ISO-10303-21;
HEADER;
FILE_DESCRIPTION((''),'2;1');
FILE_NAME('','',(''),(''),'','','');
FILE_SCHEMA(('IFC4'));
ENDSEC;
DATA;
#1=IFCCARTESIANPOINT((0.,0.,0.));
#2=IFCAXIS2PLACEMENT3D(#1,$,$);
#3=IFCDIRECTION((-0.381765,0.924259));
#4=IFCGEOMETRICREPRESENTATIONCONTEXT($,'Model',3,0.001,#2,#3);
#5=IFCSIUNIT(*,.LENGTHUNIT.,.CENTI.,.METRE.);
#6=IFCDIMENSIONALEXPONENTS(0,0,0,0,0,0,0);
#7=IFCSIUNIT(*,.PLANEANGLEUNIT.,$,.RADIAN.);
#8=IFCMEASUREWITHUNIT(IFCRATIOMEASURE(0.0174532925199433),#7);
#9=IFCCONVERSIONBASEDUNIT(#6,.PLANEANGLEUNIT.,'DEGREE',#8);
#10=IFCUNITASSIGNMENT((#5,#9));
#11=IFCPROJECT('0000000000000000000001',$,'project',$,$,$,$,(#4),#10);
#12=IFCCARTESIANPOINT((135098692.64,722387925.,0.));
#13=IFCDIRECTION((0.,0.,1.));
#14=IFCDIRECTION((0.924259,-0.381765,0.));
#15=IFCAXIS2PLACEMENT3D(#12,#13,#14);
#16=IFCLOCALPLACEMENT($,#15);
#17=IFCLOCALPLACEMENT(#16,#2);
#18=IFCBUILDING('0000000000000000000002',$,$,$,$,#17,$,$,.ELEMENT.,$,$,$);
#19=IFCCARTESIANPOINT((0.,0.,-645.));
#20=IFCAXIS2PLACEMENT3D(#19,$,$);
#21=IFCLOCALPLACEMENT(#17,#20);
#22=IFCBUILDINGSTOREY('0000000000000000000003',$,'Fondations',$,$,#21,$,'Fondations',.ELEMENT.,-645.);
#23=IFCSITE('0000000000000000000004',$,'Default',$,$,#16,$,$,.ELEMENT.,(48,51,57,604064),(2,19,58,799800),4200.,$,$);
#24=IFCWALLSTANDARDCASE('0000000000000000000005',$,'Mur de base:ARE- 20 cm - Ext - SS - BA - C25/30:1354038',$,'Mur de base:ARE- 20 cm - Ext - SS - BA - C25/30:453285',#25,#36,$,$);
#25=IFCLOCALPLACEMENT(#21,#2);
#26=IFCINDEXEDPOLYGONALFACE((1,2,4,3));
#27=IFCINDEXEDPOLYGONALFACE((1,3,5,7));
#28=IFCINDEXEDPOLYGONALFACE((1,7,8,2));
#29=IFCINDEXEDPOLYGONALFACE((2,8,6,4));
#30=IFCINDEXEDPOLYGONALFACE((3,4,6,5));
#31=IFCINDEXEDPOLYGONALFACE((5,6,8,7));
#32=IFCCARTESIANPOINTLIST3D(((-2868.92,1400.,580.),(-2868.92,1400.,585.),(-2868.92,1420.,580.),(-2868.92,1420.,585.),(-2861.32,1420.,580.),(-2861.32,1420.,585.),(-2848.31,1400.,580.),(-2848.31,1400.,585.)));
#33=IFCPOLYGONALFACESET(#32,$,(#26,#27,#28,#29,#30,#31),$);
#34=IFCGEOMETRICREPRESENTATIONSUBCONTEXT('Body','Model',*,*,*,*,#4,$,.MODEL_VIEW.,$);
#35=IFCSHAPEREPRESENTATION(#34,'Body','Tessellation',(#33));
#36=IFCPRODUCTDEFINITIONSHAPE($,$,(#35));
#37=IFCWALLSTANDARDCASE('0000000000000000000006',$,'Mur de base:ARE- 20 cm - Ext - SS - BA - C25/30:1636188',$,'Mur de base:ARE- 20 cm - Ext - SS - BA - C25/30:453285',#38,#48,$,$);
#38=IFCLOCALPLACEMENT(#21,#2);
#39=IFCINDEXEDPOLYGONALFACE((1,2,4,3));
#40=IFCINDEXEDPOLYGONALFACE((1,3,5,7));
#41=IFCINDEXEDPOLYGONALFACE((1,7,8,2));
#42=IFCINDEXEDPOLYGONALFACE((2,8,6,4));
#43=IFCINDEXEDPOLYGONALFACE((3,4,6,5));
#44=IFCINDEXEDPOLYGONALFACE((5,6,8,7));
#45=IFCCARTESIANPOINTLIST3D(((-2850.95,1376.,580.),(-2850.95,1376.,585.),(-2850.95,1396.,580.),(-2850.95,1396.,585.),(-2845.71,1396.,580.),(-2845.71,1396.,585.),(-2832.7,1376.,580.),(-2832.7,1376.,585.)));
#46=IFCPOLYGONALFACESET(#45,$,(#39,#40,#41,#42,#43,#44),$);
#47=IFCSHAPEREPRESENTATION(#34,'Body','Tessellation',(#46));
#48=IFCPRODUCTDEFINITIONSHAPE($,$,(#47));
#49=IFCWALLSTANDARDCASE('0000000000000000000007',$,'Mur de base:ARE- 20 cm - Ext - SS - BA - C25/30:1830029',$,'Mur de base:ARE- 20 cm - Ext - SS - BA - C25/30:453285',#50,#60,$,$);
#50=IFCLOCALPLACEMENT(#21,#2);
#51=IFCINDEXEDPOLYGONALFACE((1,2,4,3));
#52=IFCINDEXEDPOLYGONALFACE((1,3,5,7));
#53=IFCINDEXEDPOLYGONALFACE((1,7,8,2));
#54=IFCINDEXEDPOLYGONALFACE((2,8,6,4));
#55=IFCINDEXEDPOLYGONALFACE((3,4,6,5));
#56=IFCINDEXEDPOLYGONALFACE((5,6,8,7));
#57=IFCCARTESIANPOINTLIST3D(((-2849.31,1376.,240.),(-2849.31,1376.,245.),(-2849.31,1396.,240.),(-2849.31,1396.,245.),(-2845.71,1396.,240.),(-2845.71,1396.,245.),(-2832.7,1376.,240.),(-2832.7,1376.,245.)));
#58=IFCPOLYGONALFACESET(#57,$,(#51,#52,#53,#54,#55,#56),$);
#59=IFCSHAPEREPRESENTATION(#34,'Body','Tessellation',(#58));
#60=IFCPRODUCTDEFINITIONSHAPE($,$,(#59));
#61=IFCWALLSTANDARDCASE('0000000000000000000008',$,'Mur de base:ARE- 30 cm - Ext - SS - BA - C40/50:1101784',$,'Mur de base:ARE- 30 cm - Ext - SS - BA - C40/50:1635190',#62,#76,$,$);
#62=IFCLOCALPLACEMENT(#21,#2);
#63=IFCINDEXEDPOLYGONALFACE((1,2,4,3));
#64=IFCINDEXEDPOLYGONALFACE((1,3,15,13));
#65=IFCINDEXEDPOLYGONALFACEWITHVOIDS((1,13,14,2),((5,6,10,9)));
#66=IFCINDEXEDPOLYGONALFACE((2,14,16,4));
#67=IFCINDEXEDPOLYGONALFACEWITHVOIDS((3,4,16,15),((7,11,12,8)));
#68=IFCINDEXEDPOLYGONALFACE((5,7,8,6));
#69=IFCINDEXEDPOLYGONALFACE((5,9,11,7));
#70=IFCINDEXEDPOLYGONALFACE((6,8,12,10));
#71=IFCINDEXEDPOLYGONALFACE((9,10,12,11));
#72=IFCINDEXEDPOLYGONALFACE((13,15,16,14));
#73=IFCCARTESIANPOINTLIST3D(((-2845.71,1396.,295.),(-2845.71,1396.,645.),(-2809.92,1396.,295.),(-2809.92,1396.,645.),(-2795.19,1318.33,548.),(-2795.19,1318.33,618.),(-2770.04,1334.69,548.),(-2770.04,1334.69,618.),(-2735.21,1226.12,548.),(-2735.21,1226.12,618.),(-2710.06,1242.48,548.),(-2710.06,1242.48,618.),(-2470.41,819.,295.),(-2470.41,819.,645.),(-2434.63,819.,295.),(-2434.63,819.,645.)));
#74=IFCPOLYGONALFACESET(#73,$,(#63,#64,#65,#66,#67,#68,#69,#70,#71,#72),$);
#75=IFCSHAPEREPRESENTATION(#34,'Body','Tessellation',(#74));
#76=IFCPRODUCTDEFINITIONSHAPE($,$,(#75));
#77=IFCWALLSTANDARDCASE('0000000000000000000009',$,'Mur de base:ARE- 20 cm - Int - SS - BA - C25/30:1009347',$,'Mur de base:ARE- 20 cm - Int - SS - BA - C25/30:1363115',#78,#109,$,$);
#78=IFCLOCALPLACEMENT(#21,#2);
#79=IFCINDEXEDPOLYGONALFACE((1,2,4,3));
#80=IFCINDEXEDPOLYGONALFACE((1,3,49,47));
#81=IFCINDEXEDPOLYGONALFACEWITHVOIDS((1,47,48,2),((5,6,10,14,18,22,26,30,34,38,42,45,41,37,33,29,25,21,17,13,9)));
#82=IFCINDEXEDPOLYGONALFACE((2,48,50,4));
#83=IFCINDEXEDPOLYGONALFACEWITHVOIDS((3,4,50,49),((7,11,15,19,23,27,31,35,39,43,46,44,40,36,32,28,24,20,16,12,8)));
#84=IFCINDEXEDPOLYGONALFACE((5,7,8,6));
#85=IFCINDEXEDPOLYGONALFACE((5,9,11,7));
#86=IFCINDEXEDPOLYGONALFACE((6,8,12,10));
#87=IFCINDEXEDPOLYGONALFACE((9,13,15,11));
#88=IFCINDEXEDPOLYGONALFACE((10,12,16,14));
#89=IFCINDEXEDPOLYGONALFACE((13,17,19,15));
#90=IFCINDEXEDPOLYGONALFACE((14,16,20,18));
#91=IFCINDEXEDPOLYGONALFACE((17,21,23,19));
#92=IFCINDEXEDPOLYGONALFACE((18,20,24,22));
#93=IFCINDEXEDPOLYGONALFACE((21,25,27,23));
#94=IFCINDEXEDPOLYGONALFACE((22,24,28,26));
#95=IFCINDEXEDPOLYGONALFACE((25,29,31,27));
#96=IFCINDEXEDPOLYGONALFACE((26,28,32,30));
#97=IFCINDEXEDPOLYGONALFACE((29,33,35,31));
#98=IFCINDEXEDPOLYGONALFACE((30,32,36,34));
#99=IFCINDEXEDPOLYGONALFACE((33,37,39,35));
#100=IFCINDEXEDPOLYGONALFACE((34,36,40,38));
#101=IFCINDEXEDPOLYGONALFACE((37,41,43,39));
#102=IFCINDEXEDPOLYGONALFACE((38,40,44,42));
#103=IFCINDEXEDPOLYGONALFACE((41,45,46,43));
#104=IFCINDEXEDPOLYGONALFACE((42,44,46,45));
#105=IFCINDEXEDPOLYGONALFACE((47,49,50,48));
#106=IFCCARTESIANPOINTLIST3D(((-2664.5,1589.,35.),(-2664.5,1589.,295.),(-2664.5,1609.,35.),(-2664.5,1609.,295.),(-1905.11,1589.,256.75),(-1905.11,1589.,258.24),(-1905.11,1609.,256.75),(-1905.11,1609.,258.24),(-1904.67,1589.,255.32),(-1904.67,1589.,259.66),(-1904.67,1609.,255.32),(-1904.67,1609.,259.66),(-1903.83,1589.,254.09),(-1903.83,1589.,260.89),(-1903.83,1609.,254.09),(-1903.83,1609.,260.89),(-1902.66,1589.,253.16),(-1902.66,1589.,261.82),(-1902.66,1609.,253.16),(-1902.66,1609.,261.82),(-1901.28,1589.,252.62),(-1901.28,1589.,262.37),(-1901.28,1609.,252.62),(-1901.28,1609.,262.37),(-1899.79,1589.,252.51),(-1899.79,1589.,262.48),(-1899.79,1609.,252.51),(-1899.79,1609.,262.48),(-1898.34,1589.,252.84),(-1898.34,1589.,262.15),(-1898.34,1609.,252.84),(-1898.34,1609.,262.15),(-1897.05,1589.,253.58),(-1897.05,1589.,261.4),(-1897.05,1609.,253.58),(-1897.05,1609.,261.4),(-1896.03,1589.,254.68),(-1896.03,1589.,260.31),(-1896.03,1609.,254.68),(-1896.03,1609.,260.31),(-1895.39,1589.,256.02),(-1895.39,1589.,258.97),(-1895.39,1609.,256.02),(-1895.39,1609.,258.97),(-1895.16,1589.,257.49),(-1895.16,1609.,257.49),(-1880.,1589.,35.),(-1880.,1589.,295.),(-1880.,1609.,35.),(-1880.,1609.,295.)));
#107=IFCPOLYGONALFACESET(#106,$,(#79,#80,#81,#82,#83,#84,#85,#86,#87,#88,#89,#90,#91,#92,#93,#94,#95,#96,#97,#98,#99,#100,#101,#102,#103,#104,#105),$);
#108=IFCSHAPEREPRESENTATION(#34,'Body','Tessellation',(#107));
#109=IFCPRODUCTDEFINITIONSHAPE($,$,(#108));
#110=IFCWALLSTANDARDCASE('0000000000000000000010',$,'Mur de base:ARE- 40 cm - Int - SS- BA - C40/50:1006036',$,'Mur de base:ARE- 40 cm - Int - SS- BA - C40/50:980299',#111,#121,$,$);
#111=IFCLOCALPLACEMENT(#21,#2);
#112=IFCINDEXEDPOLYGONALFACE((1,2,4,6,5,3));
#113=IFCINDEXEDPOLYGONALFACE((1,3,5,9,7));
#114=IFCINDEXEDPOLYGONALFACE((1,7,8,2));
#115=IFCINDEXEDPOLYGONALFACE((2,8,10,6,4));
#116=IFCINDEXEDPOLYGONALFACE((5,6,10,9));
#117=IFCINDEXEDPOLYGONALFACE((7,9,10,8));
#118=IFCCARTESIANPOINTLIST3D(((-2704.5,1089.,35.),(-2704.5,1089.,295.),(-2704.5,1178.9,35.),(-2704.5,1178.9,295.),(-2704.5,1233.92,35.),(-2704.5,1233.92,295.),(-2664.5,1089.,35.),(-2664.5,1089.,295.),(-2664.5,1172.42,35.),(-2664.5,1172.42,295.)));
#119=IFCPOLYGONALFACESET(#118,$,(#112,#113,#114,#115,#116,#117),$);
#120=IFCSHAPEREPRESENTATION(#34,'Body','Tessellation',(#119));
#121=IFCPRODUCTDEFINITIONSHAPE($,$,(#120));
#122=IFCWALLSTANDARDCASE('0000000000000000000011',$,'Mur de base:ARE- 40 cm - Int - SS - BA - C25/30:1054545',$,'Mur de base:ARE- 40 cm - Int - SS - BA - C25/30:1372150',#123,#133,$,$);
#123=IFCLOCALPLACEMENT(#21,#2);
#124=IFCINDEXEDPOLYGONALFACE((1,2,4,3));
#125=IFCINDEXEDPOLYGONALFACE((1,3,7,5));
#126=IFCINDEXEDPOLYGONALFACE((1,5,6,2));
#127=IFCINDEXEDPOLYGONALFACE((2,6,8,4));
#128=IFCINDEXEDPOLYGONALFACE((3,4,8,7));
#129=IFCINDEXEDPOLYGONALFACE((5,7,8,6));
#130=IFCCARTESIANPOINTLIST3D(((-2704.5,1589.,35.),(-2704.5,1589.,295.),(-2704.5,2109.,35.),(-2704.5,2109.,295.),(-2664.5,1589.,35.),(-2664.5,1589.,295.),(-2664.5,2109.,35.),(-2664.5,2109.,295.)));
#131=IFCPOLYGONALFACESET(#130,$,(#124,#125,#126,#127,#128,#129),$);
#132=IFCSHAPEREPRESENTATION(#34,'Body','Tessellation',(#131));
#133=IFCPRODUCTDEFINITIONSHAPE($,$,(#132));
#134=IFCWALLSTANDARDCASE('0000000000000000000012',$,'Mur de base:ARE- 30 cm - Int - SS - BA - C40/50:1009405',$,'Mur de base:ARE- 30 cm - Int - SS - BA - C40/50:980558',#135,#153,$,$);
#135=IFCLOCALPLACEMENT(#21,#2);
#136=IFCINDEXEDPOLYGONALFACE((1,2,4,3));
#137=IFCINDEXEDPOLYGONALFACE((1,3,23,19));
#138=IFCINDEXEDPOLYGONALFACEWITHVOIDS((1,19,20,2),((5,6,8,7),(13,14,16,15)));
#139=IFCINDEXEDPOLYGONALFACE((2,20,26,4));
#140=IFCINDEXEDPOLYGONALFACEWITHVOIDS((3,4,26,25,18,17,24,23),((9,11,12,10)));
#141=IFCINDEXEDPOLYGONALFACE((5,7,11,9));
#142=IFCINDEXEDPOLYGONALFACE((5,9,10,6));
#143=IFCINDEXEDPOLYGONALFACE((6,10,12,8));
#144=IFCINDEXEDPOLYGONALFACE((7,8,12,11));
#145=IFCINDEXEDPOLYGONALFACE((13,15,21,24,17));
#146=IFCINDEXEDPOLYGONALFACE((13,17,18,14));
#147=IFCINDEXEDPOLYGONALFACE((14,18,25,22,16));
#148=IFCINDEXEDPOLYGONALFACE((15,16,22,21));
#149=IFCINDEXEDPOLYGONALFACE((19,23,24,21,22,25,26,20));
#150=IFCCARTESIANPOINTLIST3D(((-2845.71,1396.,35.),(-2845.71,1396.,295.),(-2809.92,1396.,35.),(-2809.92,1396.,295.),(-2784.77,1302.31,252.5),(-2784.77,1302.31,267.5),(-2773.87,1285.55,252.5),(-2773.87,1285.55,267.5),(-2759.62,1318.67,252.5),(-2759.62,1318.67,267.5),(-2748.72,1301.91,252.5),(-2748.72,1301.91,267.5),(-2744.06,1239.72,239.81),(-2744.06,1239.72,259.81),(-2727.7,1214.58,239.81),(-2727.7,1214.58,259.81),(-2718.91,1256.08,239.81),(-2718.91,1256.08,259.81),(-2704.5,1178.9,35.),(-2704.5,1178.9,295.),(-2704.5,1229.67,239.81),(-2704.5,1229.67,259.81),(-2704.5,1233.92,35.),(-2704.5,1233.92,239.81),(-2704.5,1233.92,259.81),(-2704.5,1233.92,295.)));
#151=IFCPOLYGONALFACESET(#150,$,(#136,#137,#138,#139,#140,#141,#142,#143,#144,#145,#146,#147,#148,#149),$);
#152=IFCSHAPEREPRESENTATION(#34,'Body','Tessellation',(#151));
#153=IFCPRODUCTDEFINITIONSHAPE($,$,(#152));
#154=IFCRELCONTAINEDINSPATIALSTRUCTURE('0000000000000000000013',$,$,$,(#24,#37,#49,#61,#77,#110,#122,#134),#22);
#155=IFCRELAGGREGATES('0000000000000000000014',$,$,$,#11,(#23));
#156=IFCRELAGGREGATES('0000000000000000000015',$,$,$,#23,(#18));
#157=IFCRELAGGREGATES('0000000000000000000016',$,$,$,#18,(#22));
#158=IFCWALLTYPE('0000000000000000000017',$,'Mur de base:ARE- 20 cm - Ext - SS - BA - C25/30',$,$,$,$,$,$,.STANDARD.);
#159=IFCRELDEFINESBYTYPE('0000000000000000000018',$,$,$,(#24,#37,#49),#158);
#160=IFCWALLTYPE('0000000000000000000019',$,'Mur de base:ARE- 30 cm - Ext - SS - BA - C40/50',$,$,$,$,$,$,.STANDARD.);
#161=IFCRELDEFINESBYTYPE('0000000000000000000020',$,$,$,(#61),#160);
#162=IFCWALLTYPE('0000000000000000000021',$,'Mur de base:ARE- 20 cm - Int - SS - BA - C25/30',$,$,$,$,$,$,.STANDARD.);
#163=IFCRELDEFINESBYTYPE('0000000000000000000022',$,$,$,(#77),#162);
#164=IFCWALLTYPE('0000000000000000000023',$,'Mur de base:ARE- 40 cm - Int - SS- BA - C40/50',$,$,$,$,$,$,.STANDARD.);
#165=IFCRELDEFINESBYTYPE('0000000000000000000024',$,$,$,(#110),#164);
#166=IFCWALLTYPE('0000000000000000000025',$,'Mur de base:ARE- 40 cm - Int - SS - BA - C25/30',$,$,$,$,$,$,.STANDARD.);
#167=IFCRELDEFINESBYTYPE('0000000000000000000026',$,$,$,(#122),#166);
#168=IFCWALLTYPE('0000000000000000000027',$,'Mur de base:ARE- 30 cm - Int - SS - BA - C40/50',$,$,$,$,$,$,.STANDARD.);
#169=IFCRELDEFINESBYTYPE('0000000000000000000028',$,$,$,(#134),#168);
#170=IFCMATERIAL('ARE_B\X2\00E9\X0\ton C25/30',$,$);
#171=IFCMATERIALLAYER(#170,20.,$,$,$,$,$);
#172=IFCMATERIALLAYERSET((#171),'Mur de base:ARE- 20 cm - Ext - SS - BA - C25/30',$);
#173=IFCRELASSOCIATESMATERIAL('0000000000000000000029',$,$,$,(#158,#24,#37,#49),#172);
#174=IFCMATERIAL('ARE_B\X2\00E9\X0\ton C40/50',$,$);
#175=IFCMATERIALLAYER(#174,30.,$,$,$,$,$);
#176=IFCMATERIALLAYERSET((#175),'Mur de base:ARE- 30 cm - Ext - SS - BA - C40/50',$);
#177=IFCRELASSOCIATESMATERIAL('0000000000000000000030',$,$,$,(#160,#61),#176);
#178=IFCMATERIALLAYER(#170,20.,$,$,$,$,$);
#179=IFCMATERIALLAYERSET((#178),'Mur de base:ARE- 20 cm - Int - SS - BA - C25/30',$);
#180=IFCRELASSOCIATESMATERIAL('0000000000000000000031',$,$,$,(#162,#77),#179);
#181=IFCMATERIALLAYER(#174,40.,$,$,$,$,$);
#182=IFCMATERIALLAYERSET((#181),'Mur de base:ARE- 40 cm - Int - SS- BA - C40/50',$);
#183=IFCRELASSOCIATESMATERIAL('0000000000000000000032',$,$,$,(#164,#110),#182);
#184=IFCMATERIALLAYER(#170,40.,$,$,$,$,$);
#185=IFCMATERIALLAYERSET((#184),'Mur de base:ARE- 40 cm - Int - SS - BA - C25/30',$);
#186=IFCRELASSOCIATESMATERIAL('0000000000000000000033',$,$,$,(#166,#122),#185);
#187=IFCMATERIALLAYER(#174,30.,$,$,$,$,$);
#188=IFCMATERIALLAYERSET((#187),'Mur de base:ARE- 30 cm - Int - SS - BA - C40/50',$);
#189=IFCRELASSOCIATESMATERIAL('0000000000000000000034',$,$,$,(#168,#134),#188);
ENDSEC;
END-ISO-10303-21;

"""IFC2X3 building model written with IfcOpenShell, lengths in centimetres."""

from ifc_helpers import new_model, entity, si_unit, converted_unit, direction, frame, frame_2d, origin, origin_2d_with_axis, place, context, subcontext, project, spatial, polyline, rectangle, circle, outline, extrude, material, layer, layer_set, layer_usage, type_object, element, save


model = new_model("IFC2X3")

# Units and contexts
model_context = context("Model", 3, precision=0.001, world=origin(), true_north=direction((-0.381765, 0.924259)))
body_context = subcontext(model_context, "Body", "Model", "MODEL_VIEW")
ifc_project = project(units=[si_unit("LENGTHUNIT", "METRE", prefix="CENTI"), converted_unit("PLANEANGLEUNIT", "DEGREE", entity("IfcRatioMeasure", 0.0174532925199433), si_unit("PLANEANGLEUNIT", "RADIAN"), dimensions=[0, 0, 0, 0, 0, 0, 0])], contexts=[model_context])

# Site, building, storey
site_placement = place(None, frame((135098692.64, 722387925.0, 0.0), z_axis=(0.0, 0.0, 1.0), x_axis=(0.924259, -0.381765, 0.0)))
site = spatial("IfcSite", under=ifc_project, at=site_placement, Name="Default", CompositionType="ELEMENT", RefLatitude=(48, 51, 57, 604064), RefLongitude=(2, 19, 58, 799800), RefElevation=4200.0)
building_placement = place(site_placement, origin())
building = spatial("IfcBuilding", under=site, at=building_placement, CompositionType="ELEMENT")
storey_placement = place(building_placement, frame((0.0, 0.0, -645.0)))
storey = spatial("IfcBuildingStorey", under=building, at=storey_placement, Name="Fondations", LongName="Fondations", CompositionType="ELEMENT", Elevation=-645.0)

# Shared definitions
ifc_material_1 = material(Name="ARE_Béton C25/30")

# Walls
ifc_layer_1 = layer(ifc_material_1, 20.0)
ifc_layer_set_1 = layer_set([ifc_layer_1], Name="Mur de base:ARE- 20 cm - Ext - SS - BA - C25/30")
ifc_layer_usage_1 = layer_usage(ifc_layer_set_1, "AXIS2", "NEGATIVE", 10.0)
wall_type_1 = type_object("IfcWallType", Name="Mur de base:ARE- 20 cm - Ext - SS - BA - C25/30", PredefinedType="STANDARD", material=ifc_layer_set_1)
wall_1_placement = place(storey_placement, frame((-2868.92, 1410.0, 580.0)))
element("IfcWallStandardCase", 1, at=wall_1_placement, inside=storey, type_object=wall_type_1, material=ifc_layer_usage_1, Name="Mur de base:ARE- 20 cm - Ext - SS - BA - C25/30:1354038", ObjectType="Mur de base:ARE- 20 cm - Ext - SS - BA - C25/30:453285", context=body_context, shape_type="SweptSolid", body=[
    extrude(outline(polyline([(20.61, -10.0), (7.6, 10.0), (0.0, 10.0), (0.0, -10.0), (20.61, -10.0)])), origin(), (0.0, 0.0, 1.0), 5.0),
])
ifc_layer_usage_2 = layer_usage(ifc_layer_set_1, "AXIS2", "NEGATIVE", 10.0)
wall_2_placement = place(storey_placement, frame((-2850.95, 1386.0, 580.0)))
element("IfcWallStandardCase", 2, at=wall_2_placement, inside=storey, type_object=wall_type_1, material=ifc_layer_usage_2, Name="Mur de base:ARE- 20 cm - Ext - SS - BA - C25/30:1636188", ObjectType="Mur de base:ARE- 20 cm - Ext - SS - BA - C25/30:453285", context=body_context, shape_type="SweptSolid", body=[
    extrude(outline(polyline([(18.26, -10.0), (5.25, 10.0), (0.0, 10.0), (0.0, -10.0), (18.26, -10.0)])), origin(), (0.0, 0.0, 1.0), 5.0),
])
ifc_layer_usage_3 = layer_usage(ifc_layer_set_1, "AXIS2", "NEGATIVE", 10.0)
wall_3_placement = place(storey_placement, frame((-2849.31, 1386.0, 240.0)))
element("IfcWallStandardCase", 3, at=wall_3_placement, inside=storey, type_object=wall_type_1, material=ifc_layer_usage_3, Name="Mur de base:ARE- 20 cm - Ext - SS - BA - C25/30:1830029", ObjectType="Mur de base:ARE- 20 cm - Ext - SS - BA - C25/30:453285", context=body_context, shape_type="SweptSolid", body=[
    extrude(outline(polyline([(16.61, -10.0), (3.6, 10.0), (0.0, 10.0), (0.0, -10.0), (16.61, -10.0)])), origin(), (0.0, 0.0, 1.0), 5.0),
])

# Walls, openings
ifc_material_2 = material(Name="ARE_Béton C40/50")
ifc_layer_2 = layer(ifc_material_2, 30.0)
ifc_layer_set_2 = layer_set([ifc_layer_2], Name="Mur de base:ARE- 30 cm - Ext - SS - BA - C40/50")
ifc_layer_usage_4 = layer_usage(ifc_layer_set_2, "AXIS2", "NEGATIVE", 15.0)
wall_type_2 = type_object("IfcWallType", Name="Mur de base:ARE- 30 cm - Ext - SS - BA - C40/50", PredefinedType="STANDARD", material=ifc_layer_set_2)
wall_4_placement = place(storey_placement, frame((-2833.13, 1404.18, 295.0), z_axis=(0.0, 0.0, 1.0), x_axis=(0.545236, -0.838282, 0.0)))
wall_4 = element("IfcWallStandardCase", 4, at=wall_4_placement, inside=storey, type_object=wall_type_2, material=ifc_layer_usage_4, Name="Mur de base:ARE- 30 cm - Ext - SS - BA - C40/50:1101784", ObjectType="Mur de base:ARE- 30 cm - Ext - SS - BA - C40/50:1635190", context=body_context, shape_type="SweptSolid", body=[
    extrude(outline(polyline([(688.31, -15.0), (707.82, 15.0), (672.04, 15.0), (19.51, 15.0), (0.0, -15.0), (688.31, -15.0)])), origin(), (0.0, 0.0, 1.0), 350.0),
])
opening_1_placement = place(wall_4_placement, origin())
element("IfcOpeningElement", 5, at=opening_1_placement, cuts=wall_4, ObjectType="Opening", context=body_context, shape_type="SweptSolid", body=[
    extrude(rectangle(XDim=70.0, YDim=110.0, at=frame_2d((0.0, 0.0), x_axis=(1.0, 0.0))), frame((147.65, -15.0, 288.0), z_axis=(0.0, 1.0, 0.0), x_axis=(0.0, 0.0, -1.0)), (0.0, 0.0, 1.0), 30.0),
])
ifc_layer_3 = layer(ifc_material_1, 20.0)
ifc_layer_set_3 = layer_set([ifc_layer_3], Name="Mur de base:ARE- 20 cm - Int - SS - BA - C25/30")
ifc_layer_usage_5 = layer_usage(ifc_layer_set_3, "AXIS2", "NEGATIVE", 10.0)
wall_type_3 = type_object("IfcWallType", Name="Mur de base:ARE- 20 cm - Int - SS - BA - C25/30", PredefinedType="STANDARD", material=ifc_layer_set_3)
wall_5_placement = place(storey_placement, frame((-2664.5, 1599.0, 35.0)))
wall_5 = element("IfcWallStandardCase", 6, at=wall_5_placement, inside=storey, type_object=wall_type_3, material=ifc_layer_usage_5, Name="Mur de base:ARE- 20 cm - Int - SS - BA - C25/30:1009347", ObjectType="Mur de base:ARE- 20 cm - Int - SS - BA - C25/30:1363115", context=body_context, shape_type="SweptSolid", body=[
    extrude(rectangle(XDim=784.5, YDim=20.0, at=frame_2d((392.25, 0.0), x_axis=(-1.0, 0.0))), origin(), (0.0, 0.0, 1.0), 260.0),
])
opening_2_placement = place(wall_5_placement, origin())
element("IfcOpeningElement", 7, at=opening_2_placement, cuts=wall_5, ObjectType="Opening", context=body_context, shape_type="SweptSolid", body=[
    extrude(circle(Radius=5.0, at=origin_2d_with_axis()), frame((764.34, -10.0, 222.49), z_axis=(0.0, 1.0, 0.0), x_axis=(1.0, 0.0, 0.0)), (0.0, 0.0, 1.0), 20.0),
])

# Walls
ifc_layer_4 = layer(ifc_material_2, 40.0)
ifc_layer_set_4 = layer_set([ifc_layer_4], Name="Mur de base:ARE- 40 cm - Int - SS- BA - C40/50")
ifc_layer_usage_6 = layer_usage(ifc_layer_set_4, "AXIS2", "NEGATIVE", 20.0)
wall_type_4 = type_object("IfcWallType", Name="Mur de base:ARE- 40 cm - Int - SS- BA - C40/50", PredefinedType="STANDARD", material=ifc_layer_set_4)
wall_6_placement = place(storey_placement, frame((-2684.5, 1089.0, 35.0), z_axis=(0.0, 0.0, 1.0), x_axis=(0.0, 1.0, 0.0)))
element("IfcWallStandardCase", 8, at=wall_6_placement, inside=storey, type_object=wall_type_4, material=ifc_layer_usage_6, Name="Mur de base:ARE- 40 cm - Int - SS- BA - C40/50:1006036", ObjectType="Mur de base:ARE- 40 cm - Int - SS- BA - C40/50:980299", context=body_context, shape_type="SweptSolid", body=[
    extrude(outline(polyline([(83.42, -20.0), (144.92, 20.0), (89.9, 20.0), (0.0, 20.0), (0.0, -20.0), (83.42, -20.0)])), origin(), (0.0, 0.0, 1.0), 260.0),
])
ifc_layer_5 = layer(ifc_material_1, 40.0)
ifc_layer_set_5 = layer_set([ifc_layer_5], Name="Mur de base:ARE- 40 cm - Int - SS - BA - C25/30")
ifc_layer_usage_7 = layer_usage(ifc_layer_set_5, "AXIS2", "NEGATIVE", 20.0)
wall_type_5 = type_object("IfcWallType", Name="Mur de base:ARE- 40 cm - Int - SS - BA - C25/30", PredefinedType="STANDARD", material=ifc_layer_set_5)
wall_7_placement = place(storey_placement, frame((-2684.5, 1589.0, 35.0), z_axis=(0.0, 0.0, 1.0), x_axis=(0.0, 1.0, 0.0)))
element("IfcWallStandardCase", 9, at=wall_7_placement, inside=storey, type_object=wall_type_5, material=ifc_layer_usage_7, Name="Mur de base:ARE- 40 cm - Int - SS - BA - C25/30:1054545", ObjectType="Mur de base:ARE- 40 cm - Int - SS - BA - C25/30:1372150", context=body_context, shape_type="SweptSolid", body=[
    extrude(rectangle(XDim=520.0, YDim=40.0, at=frame_2d((260.0, 0.0), x_axis=(-1.0, 0.0))), origin(), (0.0, 0.0, 1.0), 260.0),
])

# Wall, openings
ifc_layer_6 = layer(ifc_material_2, 30.0)
ifc_layer_set_6 = layer_set([ifc_layer_6], Name="Mur de base:ARE- 30 cm - Int - SS - BA - C40/50")
ifc_layer_usage_8 = layer_usage(ifc_layer_set_6, "AXIS2", "NEGATIVE", 15.0)
wall_type_6 = type_object("IfcWallType", Name="Mur de base:ARE- 30 cm - Int - SS - BA - C40/50", PredefinedType="STANDARD", material=ifc_layer_set_6)
wall_8_placement = place(storey_placement, frame((-2691.93, 1187.08, 35.0), z_axis=(0.0, 0.0, 1.0), x_axis=(-0.545236, 0.838282, 0.0)))
wall_8 = element("IfcWallStandardCase", 10, at=wall_8_placement, inside=storey, type_object=wall_type_6, material=ifc_layer_usage_8, Name="Mur de base:ARE- 30 cm - Int - SS - BA - C40/50:1009405", ObjectType="Mur de base:ARE- 30 cm - Int - SS - BA - C40/50:980558", context=body_context, shape_type="SweptSolid", body=[
    extrude(outline(polyline([(239.47, -15.0), (258.98, 15.0), (0.0, 15.0), (46.12, -15.0), (239.47, -15.0)])), origin(), (0.0, 0.0, 1.0), 260.0),
])
opening_3_placement = place(wall_8_placement, origin())
element("IfcOpeningElement", 11, at=opening_3_placement, cuts=wall_8, ObjectType="Opening", context=body_context, shape_type="SweptSolid", body=[
    extrude(rectangle(XDim=15.0, YDim=20.0, at=frame_2d((0.0, 0.0), x_axis=(1.0, 0.0))), frame((137.22, -15.0, 225.0), z_axis=(0.0, 1.0, 0.0), x_axis=(0.0, 0.0, -1.0)), (0.0, 0.0, 1.0), 30.0),
])
opening_4_placement = place(wall_8_placement, origin())
element("IfcOpeningElement", 12, at=opening_4_placement, cuts=wall_8, ObjectType="Opening", context=body_context, shape_type="SweptSolid", body=[
    extrude(rectangle(XDim=20.0, YDim=30.0, at=frame_2d((0.0, 0.0), x_axis=(1.0, 0.0))), frame((57.56, -15.0, 214.81), z_axis=(0.0, 1.0, 0.0), x_axis=(0.0, 0.0, -1.0)), (0.0, 0.0, 1.0), 30.0),
])

save(model, "model.ifc")
